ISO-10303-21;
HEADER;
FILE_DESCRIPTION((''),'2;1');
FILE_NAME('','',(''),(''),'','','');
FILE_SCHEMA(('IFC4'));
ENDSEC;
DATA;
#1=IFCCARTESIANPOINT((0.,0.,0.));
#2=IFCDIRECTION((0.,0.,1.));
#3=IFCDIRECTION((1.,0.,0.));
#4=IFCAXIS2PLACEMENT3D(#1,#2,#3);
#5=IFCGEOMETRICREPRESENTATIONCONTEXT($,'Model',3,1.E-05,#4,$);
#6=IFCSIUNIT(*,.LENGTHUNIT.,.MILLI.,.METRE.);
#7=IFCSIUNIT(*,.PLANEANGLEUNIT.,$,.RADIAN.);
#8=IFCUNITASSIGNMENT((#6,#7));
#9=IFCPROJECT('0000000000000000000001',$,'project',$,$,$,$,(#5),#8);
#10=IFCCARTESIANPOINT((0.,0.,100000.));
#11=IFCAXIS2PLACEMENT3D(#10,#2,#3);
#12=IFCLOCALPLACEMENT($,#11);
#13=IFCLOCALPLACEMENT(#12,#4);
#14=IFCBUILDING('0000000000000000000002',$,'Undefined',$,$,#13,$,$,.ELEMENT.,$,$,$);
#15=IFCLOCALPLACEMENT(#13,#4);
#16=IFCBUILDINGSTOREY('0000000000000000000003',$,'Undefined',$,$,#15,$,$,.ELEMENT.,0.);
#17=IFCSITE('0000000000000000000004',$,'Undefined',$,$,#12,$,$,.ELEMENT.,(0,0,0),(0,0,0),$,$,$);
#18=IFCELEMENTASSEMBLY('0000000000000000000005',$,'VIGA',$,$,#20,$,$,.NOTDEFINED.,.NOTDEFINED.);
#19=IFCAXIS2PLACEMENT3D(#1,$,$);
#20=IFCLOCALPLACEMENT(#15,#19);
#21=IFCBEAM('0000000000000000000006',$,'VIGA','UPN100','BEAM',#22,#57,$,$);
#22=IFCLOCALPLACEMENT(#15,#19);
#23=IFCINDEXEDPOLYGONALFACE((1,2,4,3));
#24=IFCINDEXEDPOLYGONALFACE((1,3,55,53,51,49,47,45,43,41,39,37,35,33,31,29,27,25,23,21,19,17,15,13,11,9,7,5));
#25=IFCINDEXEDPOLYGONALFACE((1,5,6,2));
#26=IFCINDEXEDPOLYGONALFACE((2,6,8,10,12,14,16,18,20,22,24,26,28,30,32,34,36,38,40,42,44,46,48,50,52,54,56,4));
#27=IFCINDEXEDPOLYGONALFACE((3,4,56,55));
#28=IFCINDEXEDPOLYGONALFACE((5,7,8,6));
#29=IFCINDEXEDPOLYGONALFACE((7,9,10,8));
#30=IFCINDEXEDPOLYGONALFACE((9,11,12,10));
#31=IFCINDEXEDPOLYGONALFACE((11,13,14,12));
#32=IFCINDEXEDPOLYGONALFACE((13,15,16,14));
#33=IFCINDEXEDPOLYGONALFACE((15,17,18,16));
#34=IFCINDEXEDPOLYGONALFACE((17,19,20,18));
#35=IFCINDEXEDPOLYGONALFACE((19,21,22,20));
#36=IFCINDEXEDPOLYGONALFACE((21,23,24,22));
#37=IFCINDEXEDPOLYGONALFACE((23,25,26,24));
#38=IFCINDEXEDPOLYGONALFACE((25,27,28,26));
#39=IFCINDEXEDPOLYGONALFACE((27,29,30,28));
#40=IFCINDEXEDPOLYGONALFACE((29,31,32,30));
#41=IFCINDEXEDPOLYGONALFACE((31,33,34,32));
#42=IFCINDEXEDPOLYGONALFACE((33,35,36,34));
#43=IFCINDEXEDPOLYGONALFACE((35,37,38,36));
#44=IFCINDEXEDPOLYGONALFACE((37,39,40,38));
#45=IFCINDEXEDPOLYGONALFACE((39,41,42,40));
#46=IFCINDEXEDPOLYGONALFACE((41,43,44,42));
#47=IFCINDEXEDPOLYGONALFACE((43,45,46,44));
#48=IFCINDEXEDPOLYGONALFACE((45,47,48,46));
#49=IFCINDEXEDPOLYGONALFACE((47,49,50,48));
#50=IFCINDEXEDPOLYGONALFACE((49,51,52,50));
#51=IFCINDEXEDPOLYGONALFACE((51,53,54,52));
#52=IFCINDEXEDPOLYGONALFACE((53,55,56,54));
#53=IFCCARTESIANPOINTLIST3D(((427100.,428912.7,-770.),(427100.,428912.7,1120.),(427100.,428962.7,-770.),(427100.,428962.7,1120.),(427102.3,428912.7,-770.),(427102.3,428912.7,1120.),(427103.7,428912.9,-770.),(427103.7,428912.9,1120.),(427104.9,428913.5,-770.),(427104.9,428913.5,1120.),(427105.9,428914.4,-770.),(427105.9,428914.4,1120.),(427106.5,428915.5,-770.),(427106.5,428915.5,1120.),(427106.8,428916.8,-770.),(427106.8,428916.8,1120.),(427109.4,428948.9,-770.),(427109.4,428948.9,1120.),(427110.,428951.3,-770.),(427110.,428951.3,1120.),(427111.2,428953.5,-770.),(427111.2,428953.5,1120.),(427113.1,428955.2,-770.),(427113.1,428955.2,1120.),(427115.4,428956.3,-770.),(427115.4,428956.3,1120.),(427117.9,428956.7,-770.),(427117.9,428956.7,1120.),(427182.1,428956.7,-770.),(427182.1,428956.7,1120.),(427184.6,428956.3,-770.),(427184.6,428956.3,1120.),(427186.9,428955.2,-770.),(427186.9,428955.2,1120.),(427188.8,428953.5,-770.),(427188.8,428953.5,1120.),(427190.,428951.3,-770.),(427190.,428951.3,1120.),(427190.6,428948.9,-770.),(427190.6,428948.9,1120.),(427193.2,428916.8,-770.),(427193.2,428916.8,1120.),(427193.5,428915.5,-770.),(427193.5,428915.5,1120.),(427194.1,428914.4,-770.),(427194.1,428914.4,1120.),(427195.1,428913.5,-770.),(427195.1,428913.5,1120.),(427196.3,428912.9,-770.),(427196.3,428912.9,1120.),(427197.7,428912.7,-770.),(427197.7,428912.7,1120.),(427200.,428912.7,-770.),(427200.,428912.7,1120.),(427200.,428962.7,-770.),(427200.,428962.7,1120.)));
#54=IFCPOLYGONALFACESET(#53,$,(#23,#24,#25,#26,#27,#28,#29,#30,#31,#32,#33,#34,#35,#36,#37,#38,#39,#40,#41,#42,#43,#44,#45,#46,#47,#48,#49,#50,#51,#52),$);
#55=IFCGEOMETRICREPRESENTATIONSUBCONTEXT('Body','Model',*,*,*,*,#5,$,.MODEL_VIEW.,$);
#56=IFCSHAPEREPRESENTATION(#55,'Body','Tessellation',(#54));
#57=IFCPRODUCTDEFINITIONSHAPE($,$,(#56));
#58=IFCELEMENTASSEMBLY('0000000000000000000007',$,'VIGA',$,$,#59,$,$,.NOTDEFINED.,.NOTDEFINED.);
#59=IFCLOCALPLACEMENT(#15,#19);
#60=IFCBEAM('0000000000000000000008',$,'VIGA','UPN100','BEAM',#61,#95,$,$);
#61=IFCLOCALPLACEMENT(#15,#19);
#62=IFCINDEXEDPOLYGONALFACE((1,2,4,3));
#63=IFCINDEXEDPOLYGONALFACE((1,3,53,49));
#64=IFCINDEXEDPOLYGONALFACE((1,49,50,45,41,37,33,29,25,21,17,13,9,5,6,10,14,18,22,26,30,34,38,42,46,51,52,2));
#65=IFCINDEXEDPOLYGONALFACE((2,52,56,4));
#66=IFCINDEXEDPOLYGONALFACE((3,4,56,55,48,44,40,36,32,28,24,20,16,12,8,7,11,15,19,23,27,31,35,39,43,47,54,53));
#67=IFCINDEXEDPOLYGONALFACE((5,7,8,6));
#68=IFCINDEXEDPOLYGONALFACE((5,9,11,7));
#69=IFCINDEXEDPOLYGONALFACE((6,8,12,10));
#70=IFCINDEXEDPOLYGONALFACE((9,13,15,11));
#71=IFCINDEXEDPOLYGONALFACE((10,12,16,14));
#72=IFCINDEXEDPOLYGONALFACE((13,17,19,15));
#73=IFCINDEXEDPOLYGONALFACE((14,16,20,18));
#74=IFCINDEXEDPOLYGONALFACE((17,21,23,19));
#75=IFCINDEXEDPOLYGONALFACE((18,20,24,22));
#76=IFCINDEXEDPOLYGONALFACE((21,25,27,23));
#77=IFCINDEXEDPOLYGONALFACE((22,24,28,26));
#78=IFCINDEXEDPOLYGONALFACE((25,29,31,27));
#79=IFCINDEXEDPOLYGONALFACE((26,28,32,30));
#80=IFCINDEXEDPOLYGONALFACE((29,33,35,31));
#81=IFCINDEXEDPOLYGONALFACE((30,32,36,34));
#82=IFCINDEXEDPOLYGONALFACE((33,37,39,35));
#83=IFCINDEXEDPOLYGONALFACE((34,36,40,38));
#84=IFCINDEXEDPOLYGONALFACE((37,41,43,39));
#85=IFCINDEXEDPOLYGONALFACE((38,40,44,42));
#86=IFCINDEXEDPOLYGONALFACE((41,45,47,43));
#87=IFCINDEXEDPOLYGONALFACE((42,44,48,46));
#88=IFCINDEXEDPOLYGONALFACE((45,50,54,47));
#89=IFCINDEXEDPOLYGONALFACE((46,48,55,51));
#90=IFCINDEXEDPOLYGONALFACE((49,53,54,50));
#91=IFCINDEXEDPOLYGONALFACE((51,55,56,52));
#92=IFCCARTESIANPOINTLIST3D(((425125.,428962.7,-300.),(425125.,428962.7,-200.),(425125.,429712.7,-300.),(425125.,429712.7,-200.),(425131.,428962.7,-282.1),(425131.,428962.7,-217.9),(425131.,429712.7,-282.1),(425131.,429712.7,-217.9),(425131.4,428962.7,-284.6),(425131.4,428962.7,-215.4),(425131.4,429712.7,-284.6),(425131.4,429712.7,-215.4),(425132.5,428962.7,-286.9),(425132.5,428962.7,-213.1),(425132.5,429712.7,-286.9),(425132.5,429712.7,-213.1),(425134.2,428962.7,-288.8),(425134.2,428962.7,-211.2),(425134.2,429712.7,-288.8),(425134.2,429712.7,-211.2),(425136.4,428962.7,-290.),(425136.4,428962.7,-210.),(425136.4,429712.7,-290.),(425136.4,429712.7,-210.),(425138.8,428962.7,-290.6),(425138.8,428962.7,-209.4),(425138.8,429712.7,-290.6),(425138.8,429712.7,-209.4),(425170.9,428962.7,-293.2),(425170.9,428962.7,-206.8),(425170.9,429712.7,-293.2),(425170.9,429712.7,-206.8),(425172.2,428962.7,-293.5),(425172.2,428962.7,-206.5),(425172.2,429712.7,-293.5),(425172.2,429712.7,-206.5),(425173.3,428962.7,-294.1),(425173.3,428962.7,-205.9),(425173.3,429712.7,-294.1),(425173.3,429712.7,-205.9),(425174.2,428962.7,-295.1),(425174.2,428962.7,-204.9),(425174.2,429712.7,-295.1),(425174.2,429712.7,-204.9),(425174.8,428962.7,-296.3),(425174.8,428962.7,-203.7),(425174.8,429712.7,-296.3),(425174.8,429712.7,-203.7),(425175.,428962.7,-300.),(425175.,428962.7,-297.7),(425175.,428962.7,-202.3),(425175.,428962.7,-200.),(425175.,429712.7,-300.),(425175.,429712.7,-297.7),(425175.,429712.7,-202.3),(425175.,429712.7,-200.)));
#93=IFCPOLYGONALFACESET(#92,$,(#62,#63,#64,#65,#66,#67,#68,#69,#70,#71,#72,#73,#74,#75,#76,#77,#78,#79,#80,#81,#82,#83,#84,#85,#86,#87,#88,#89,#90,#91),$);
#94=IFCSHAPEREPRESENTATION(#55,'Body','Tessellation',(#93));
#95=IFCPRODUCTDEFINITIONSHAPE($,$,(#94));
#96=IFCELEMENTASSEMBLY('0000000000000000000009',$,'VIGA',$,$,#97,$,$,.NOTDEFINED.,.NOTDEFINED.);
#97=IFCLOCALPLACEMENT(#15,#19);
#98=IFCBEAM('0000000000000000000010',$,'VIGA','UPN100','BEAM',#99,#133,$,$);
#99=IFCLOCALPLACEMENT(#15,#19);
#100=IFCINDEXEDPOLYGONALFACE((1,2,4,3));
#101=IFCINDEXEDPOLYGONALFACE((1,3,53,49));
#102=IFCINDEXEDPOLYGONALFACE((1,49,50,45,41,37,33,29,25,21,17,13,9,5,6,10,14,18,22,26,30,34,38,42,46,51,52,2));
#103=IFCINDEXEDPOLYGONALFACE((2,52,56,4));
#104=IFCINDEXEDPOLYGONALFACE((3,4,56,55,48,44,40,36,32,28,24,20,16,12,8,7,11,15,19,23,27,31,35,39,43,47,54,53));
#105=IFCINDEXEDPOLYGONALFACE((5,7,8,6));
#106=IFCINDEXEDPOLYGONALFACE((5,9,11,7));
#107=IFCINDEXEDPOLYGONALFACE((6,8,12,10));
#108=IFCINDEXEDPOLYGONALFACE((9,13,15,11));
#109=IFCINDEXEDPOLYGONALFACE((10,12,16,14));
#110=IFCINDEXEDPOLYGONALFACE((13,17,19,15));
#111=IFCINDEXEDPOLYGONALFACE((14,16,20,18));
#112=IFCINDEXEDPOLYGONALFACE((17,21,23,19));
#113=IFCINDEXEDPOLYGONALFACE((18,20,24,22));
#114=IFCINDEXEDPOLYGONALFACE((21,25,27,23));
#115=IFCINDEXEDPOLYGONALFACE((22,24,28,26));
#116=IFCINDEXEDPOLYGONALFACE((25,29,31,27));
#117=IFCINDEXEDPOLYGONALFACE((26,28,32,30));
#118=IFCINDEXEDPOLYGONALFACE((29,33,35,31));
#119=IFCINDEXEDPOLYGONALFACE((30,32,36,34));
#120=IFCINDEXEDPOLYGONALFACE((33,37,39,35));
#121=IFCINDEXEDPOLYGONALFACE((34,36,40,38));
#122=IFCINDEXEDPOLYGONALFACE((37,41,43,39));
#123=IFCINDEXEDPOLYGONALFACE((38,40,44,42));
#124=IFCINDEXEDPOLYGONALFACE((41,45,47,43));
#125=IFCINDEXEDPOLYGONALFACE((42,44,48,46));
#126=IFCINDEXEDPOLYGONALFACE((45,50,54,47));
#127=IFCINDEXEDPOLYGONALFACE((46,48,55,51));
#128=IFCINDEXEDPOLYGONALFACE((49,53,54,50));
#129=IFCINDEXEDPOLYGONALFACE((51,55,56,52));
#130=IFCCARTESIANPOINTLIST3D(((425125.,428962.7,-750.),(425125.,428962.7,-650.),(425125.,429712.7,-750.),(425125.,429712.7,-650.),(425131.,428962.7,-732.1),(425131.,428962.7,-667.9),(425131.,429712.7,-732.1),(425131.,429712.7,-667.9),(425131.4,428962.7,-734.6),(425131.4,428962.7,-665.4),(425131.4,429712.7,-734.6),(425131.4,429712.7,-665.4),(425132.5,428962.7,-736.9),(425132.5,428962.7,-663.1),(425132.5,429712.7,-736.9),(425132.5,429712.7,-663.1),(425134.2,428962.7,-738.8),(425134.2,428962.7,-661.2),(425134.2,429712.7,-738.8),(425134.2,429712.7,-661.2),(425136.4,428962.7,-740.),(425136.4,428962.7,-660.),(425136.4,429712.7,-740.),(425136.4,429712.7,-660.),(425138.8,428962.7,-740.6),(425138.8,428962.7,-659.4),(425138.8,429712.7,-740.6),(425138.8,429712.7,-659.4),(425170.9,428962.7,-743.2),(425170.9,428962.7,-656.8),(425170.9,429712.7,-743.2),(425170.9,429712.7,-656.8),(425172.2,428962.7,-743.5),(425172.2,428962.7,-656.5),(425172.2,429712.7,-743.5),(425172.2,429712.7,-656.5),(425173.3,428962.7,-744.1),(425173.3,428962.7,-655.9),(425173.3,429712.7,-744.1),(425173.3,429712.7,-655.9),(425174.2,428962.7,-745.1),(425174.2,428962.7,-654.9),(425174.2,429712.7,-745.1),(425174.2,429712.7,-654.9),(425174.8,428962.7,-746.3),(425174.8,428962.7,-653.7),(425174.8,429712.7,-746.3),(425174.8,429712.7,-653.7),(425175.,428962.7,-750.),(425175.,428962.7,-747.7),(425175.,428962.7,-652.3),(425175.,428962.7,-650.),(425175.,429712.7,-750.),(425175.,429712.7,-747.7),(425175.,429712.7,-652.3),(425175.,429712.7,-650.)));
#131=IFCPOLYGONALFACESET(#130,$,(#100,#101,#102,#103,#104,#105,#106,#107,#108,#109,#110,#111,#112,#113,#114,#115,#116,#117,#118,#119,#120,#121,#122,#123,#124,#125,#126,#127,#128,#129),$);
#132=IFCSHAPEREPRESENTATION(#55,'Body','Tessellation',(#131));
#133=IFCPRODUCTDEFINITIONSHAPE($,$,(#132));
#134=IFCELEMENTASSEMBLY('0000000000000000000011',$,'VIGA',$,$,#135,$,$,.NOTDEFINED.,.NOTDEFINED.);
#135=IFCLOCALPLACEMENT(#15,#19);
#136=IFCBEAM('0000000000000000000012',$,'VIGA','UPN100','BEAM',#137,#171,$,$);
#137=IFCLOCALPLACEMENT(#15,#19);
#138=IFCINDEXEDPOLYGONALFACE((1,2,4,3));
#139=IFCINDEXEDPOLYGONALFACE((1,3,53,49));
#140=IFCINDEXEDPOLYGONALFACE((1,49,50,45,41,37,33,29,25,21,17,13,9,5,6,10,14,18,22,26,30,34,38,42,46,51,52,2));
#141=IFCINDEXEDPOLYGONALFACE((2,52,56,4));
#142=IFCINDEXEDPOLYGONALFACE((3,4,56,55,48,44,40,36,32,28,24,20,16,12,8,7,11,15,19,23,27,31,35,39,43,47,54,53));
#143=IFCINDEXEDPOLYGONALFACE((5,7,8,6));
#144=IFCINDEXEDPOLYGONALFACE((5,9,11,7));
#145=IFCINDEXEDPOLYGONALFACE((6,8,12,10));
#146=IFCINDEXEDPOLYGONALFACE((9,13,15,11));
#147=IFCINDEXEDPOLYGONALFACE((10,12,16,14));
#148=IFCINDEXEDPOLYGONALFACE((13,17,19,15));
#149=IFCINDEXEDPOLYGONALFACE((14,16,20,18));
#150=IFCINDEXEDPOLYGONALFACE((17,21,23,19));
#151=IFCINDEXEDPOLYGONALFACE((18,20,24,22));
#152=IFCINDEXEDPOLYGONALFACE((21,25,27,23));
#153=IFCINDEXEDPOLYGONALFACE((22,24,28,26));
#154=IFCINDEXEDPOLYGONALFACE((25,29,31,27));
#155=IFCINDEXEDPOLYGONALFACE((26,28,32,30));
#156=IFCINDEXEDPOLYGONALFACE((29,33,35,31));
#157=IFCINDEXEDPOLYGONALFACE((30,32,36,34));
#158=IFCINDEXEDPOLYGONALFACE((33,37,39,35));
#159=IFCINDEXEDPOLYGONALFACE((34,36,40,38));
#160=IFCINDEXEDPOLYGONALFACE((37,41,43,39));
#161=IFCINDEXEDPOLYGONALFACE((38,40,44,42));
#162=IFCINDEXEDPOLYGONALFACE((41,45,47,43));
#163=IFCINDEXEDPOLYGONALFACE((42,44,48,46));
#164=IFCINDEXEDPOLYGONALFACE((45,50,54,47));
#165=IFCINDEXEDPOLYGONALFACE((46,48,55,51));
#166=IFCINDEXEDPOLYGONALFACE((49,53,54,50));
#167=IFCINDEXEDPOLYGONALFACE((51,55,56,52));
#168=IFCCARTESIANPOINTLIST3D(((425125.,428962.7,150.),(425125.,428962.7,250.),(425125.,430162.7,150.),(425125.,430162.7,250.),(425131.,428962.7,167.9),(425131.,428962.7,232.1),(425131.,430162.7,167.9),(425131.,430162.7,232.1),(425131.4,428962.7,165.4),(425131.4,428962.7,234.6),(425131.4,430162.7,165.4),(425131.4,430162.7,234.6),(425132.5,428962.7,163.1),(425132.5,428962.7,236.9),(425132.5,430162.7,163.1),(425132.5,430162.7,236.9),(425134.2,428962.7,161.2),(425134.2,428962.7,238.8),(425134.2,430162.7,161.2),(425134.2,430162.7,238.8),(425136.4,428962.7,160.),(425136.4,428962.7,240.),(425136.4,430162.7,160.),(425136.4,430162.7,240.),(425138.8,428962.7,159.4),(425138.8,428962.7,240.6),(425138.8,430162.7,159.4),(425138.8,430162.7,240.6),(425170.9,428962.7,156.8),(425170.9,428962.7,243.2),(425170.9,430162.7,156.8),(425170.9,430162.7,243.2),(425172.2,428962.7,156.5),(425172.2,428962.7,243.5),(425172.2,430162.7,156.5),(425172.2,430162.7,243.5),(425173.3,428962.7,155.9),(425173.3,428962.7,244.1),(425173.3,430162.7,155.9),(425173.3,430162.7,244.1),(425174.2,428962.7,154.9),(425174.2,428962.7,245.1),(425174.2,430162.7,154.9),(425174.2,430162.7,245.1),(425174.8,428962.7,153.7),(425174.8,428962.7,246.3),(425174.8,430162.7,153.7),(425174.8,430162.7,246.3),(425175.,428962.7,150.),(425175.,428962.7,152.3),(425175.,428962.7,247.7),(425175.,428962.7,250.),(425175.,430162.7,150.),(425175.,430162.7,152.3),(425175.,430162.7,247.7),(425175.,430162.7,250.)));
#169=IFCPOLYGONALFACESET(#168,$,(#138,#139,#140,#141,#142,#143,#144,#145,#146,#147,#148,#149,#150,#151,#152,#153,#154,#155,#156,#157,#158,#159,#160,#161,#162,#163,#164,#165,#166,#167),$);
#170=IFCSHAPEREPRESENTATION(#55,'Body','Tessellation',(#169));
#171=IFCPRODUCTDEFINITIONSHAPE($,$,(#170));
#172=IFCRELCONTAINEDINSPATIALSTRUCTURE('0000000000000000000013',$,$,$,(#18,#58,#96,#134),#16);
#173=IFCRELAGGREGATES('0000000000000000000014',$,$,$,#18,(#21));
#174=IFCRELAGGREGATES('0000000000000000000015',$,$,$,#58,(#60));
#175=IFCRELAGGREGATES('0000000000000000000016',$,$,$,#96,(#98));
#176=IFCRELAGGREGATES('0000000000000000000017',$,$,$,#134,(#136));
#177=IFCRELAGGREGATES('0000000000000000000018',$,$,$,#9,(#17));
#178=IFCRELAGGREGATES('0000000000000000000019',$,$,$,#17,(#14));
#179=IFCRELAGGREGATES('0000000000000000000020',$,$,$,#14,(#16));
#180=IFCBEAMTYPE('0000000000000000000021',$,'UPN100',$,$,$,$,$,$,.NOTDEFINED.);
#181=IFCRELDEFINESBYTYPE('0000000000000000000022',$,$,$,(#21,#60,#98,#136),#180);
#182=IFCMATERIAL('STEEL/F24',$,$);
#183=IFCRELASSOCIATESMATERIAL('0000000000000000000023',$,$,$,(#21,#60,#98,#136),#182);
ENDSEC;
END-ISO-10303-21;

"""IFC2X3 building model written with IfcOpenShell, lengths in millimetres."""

from ifc_helpers import new_model, si_unit, frame, origin_with_axes, origin_2d_with_axis, place, context, subcontext, project, spatial, u_section, extrude, material, type_object, element, aggregate, save


model = new_model("IFC2X3")

# Units and contexts
model_context = context("Model", 3, precision=1e-05, world=origin_with_axes())
body_context = subcontext(model_context, "Body", "Model", "MODEL_VIEW")
ifc_project = project(units=[si_unit("LENGTHUNIT", "METRE", prefix="MILLI"), si_unit("PLANEANGLEUNIT", "RADIAN")], contexts=[model_context])

# Site, building, storey
site_placement = place(None, frame((0.0, 0.0, 100000.0), z_axis=(0.0, 0.0, 1.0), x_axis=(1.0, 0.0, 0.0)))
site = spatial("IfcSite", under=ifc_project, at=site_placement, Name="Undefined", CompositionType="ELEMENT", RefLatitude=(0, 0, 0), RefLongitude=(0, 0, 0))
building_placement = place(site_placement, origin_with_axes())
building = spatial("IfcBuilding", under=site, at=building_placement, Name="Undefined", CompositionType="ELEMENT")
storey_placement = place(building_placement, origin_with_axes())
storey = spatial("IfcBuildingStorey", under=building, at=storey_placement, Name="Undefined", CompositionType="ELEMENT", Elevation=0.0)

# Element assemblies, beams
ifc_material_1 = material(Name="STEEL/F24")
beam_type = type_object("IfcBeamType", Name="UPN100", PredefinedType="NOTDEFINED")
assembly_1_placement = place(storey_placement, origin_with_axes())
assembly_1 = element("IfcElementAssembly", 1, at=assembly_1_placement, inside=storey, Name="VIGA", AssemblyPlace="NOTDEFINED", PredefinedType="NOTDEFINED")
beam_1_placement = place(assembly_1_placement, frame((427150.0, 428937.7, 1120.0), z_axis=(1.0, 0.0, 0.0), x_axis=(0.0, 0.0, -1.0)))
beam_1 = element("IfcBeam", 2, at=beam_1_placement, type_object=beam_type, material=ifc_material_1, Name="VIGA", Description="UPN100", ObjectType="BEAM", context=body_context, shape_type="SweptSolid", body=[
    extrude(u_section(Depth=100.0, FlangeWidth=50.0, WebThickness=6.0, FlangeThickness=8.5, FilletRadius=8.5, EdgeRadius=4.5, FlangeSlope=0.07983, at=origin_2d_with_axis()), frame((1890.0, 0.0, 0.0), z_axis=(-1.0, 0.0, 0.0), x_axis=(0.0, -1.0, 0.0)), (0.0, 0.0, 1.0), 1890.0),
])
aggregate(assembly_1, [beam_1])
assembly_2_placement = place(storey_placement, origin_with_axes())
assembly_2 = element("IfcElementAssembly", 3, at=assembly_2_placement, inside=storey, Name="VIGA", AssemblyPlace="NOTDEFINED", PredefinedType="NOTDEFINED")
beam_2_placement = place(assembly_2_placement, frame((425150.0, 428962.7, -250.0), z_axis=(0.0, 0.0, 1.0), x_axis=(0.0, 1.0, 0.0)))
beam_2 = element("IfcBeam", 4, at=beam_2_placement, type_object=beam_type, material=ifc_material_1, Name="VIGA", Description="UPN100", ObjectType="BEAM", context=body_context, shape_type="SweptSolid", body=[
    extrude(u_section(Depth=100.0, FlangeWidth=50.0, WebThickness=6.0, FlangeThickness=8.5, FilletRadius=8.5, EdgeRadius=4.5, FlangeSlope=0.07983, at=origin_2d_with_axis()), frame((750.0, 0.0, 0.0), z_axis=(-1.0, 0.0, 0.0), x_axis=(0.0, -1.0, 0.0)), (0.0, 0.0, 1.0), 750.0),
])
aggregate(assembly_2, [beam_2])
assembly_3_placement = place(storey_placement, origin_with_axes())
assembly_3 = element("IfcElementAssembly", 5, at=assembly_3_placement, inside=storey, Name="VIGA", AssemblyPlace="NOTDEFINED", PredefinedType="NOTDEFINED")
beam_3_placement = place(assembly_3_placement, frame((425150.0, 428962.7, -700.0), z_axis=(0.0, 0.0, 1.0), x_axis=(0.0, 1.0, 0.0)))
beam_3 = element("IfcBeam", 6, at=beam_3_placement, type_object=beam_type, material=ifc_material_1, Name="VIGA", Description="UPN100", ObjectType="BEAM", context=body_context, shape_type="SweptSolid", body=[
    extrude(u_section(Depth=100.0, FlangeWidth=50.0, WebThickness=6.0, FlangeThickness=8.5, FilletRadius=8.5, EdgeRadius=4.5, FlangeSlope=0.07983, at=origin_2d_with_axis()), frame((750.0, 0.0, 0.0), z_axis=(-1.0, 0.0, 0.0), x_axis=(0.0, -1.0, 0.0)), (0.0, 0.0, 1.0), 750.0),
])
aggregate(assembly_3, [beam_3])
assembly_4_placement = place(storey_placement, origin_with_axes())
assembly_4 = element("IfcElementAssembly", 7, at=assembly_4_placement, inside=storey, Name="VIGA", AssemblyPlace="NOTDEFINED", PredefinedType="NOTDEFINED")
beam_4_placement = place(assembly_4_placement, frame((425150.0, 428962.7, 200.0), z_axis=(0.0, 0.0, 1.0), x_axis=(0.0, 1.0, 0.0)))
beam_4 = element("IfcBeam", 8, at=beam_4_placement, type_object=beam_type, material=ifc_material_1, Name="VIGA", Description="UPN100", ObjectType="BEAM", context=body_context, shape_type="SweptSolid", body=[
    extrude(u_section(Depth=100.0, FlangeWidth=50.0, WebThickness=6.0, FlangeThickness=8.5, FilletRadius=8.5, EdgeRadius=4.5, FlangeSlope=0.07983, at=origin_2d_with_axis()), frame((1200.0, 0.0, 0.0), z_axis=(-1.0, 0.0, 0.0), x_axis=(0.0, -1.0, 0.0)), (0.0, 0.0, 1.0), 1200.0),
])
aggregate(assembly_4, [beam_4])

save(model, "model.ifc")
